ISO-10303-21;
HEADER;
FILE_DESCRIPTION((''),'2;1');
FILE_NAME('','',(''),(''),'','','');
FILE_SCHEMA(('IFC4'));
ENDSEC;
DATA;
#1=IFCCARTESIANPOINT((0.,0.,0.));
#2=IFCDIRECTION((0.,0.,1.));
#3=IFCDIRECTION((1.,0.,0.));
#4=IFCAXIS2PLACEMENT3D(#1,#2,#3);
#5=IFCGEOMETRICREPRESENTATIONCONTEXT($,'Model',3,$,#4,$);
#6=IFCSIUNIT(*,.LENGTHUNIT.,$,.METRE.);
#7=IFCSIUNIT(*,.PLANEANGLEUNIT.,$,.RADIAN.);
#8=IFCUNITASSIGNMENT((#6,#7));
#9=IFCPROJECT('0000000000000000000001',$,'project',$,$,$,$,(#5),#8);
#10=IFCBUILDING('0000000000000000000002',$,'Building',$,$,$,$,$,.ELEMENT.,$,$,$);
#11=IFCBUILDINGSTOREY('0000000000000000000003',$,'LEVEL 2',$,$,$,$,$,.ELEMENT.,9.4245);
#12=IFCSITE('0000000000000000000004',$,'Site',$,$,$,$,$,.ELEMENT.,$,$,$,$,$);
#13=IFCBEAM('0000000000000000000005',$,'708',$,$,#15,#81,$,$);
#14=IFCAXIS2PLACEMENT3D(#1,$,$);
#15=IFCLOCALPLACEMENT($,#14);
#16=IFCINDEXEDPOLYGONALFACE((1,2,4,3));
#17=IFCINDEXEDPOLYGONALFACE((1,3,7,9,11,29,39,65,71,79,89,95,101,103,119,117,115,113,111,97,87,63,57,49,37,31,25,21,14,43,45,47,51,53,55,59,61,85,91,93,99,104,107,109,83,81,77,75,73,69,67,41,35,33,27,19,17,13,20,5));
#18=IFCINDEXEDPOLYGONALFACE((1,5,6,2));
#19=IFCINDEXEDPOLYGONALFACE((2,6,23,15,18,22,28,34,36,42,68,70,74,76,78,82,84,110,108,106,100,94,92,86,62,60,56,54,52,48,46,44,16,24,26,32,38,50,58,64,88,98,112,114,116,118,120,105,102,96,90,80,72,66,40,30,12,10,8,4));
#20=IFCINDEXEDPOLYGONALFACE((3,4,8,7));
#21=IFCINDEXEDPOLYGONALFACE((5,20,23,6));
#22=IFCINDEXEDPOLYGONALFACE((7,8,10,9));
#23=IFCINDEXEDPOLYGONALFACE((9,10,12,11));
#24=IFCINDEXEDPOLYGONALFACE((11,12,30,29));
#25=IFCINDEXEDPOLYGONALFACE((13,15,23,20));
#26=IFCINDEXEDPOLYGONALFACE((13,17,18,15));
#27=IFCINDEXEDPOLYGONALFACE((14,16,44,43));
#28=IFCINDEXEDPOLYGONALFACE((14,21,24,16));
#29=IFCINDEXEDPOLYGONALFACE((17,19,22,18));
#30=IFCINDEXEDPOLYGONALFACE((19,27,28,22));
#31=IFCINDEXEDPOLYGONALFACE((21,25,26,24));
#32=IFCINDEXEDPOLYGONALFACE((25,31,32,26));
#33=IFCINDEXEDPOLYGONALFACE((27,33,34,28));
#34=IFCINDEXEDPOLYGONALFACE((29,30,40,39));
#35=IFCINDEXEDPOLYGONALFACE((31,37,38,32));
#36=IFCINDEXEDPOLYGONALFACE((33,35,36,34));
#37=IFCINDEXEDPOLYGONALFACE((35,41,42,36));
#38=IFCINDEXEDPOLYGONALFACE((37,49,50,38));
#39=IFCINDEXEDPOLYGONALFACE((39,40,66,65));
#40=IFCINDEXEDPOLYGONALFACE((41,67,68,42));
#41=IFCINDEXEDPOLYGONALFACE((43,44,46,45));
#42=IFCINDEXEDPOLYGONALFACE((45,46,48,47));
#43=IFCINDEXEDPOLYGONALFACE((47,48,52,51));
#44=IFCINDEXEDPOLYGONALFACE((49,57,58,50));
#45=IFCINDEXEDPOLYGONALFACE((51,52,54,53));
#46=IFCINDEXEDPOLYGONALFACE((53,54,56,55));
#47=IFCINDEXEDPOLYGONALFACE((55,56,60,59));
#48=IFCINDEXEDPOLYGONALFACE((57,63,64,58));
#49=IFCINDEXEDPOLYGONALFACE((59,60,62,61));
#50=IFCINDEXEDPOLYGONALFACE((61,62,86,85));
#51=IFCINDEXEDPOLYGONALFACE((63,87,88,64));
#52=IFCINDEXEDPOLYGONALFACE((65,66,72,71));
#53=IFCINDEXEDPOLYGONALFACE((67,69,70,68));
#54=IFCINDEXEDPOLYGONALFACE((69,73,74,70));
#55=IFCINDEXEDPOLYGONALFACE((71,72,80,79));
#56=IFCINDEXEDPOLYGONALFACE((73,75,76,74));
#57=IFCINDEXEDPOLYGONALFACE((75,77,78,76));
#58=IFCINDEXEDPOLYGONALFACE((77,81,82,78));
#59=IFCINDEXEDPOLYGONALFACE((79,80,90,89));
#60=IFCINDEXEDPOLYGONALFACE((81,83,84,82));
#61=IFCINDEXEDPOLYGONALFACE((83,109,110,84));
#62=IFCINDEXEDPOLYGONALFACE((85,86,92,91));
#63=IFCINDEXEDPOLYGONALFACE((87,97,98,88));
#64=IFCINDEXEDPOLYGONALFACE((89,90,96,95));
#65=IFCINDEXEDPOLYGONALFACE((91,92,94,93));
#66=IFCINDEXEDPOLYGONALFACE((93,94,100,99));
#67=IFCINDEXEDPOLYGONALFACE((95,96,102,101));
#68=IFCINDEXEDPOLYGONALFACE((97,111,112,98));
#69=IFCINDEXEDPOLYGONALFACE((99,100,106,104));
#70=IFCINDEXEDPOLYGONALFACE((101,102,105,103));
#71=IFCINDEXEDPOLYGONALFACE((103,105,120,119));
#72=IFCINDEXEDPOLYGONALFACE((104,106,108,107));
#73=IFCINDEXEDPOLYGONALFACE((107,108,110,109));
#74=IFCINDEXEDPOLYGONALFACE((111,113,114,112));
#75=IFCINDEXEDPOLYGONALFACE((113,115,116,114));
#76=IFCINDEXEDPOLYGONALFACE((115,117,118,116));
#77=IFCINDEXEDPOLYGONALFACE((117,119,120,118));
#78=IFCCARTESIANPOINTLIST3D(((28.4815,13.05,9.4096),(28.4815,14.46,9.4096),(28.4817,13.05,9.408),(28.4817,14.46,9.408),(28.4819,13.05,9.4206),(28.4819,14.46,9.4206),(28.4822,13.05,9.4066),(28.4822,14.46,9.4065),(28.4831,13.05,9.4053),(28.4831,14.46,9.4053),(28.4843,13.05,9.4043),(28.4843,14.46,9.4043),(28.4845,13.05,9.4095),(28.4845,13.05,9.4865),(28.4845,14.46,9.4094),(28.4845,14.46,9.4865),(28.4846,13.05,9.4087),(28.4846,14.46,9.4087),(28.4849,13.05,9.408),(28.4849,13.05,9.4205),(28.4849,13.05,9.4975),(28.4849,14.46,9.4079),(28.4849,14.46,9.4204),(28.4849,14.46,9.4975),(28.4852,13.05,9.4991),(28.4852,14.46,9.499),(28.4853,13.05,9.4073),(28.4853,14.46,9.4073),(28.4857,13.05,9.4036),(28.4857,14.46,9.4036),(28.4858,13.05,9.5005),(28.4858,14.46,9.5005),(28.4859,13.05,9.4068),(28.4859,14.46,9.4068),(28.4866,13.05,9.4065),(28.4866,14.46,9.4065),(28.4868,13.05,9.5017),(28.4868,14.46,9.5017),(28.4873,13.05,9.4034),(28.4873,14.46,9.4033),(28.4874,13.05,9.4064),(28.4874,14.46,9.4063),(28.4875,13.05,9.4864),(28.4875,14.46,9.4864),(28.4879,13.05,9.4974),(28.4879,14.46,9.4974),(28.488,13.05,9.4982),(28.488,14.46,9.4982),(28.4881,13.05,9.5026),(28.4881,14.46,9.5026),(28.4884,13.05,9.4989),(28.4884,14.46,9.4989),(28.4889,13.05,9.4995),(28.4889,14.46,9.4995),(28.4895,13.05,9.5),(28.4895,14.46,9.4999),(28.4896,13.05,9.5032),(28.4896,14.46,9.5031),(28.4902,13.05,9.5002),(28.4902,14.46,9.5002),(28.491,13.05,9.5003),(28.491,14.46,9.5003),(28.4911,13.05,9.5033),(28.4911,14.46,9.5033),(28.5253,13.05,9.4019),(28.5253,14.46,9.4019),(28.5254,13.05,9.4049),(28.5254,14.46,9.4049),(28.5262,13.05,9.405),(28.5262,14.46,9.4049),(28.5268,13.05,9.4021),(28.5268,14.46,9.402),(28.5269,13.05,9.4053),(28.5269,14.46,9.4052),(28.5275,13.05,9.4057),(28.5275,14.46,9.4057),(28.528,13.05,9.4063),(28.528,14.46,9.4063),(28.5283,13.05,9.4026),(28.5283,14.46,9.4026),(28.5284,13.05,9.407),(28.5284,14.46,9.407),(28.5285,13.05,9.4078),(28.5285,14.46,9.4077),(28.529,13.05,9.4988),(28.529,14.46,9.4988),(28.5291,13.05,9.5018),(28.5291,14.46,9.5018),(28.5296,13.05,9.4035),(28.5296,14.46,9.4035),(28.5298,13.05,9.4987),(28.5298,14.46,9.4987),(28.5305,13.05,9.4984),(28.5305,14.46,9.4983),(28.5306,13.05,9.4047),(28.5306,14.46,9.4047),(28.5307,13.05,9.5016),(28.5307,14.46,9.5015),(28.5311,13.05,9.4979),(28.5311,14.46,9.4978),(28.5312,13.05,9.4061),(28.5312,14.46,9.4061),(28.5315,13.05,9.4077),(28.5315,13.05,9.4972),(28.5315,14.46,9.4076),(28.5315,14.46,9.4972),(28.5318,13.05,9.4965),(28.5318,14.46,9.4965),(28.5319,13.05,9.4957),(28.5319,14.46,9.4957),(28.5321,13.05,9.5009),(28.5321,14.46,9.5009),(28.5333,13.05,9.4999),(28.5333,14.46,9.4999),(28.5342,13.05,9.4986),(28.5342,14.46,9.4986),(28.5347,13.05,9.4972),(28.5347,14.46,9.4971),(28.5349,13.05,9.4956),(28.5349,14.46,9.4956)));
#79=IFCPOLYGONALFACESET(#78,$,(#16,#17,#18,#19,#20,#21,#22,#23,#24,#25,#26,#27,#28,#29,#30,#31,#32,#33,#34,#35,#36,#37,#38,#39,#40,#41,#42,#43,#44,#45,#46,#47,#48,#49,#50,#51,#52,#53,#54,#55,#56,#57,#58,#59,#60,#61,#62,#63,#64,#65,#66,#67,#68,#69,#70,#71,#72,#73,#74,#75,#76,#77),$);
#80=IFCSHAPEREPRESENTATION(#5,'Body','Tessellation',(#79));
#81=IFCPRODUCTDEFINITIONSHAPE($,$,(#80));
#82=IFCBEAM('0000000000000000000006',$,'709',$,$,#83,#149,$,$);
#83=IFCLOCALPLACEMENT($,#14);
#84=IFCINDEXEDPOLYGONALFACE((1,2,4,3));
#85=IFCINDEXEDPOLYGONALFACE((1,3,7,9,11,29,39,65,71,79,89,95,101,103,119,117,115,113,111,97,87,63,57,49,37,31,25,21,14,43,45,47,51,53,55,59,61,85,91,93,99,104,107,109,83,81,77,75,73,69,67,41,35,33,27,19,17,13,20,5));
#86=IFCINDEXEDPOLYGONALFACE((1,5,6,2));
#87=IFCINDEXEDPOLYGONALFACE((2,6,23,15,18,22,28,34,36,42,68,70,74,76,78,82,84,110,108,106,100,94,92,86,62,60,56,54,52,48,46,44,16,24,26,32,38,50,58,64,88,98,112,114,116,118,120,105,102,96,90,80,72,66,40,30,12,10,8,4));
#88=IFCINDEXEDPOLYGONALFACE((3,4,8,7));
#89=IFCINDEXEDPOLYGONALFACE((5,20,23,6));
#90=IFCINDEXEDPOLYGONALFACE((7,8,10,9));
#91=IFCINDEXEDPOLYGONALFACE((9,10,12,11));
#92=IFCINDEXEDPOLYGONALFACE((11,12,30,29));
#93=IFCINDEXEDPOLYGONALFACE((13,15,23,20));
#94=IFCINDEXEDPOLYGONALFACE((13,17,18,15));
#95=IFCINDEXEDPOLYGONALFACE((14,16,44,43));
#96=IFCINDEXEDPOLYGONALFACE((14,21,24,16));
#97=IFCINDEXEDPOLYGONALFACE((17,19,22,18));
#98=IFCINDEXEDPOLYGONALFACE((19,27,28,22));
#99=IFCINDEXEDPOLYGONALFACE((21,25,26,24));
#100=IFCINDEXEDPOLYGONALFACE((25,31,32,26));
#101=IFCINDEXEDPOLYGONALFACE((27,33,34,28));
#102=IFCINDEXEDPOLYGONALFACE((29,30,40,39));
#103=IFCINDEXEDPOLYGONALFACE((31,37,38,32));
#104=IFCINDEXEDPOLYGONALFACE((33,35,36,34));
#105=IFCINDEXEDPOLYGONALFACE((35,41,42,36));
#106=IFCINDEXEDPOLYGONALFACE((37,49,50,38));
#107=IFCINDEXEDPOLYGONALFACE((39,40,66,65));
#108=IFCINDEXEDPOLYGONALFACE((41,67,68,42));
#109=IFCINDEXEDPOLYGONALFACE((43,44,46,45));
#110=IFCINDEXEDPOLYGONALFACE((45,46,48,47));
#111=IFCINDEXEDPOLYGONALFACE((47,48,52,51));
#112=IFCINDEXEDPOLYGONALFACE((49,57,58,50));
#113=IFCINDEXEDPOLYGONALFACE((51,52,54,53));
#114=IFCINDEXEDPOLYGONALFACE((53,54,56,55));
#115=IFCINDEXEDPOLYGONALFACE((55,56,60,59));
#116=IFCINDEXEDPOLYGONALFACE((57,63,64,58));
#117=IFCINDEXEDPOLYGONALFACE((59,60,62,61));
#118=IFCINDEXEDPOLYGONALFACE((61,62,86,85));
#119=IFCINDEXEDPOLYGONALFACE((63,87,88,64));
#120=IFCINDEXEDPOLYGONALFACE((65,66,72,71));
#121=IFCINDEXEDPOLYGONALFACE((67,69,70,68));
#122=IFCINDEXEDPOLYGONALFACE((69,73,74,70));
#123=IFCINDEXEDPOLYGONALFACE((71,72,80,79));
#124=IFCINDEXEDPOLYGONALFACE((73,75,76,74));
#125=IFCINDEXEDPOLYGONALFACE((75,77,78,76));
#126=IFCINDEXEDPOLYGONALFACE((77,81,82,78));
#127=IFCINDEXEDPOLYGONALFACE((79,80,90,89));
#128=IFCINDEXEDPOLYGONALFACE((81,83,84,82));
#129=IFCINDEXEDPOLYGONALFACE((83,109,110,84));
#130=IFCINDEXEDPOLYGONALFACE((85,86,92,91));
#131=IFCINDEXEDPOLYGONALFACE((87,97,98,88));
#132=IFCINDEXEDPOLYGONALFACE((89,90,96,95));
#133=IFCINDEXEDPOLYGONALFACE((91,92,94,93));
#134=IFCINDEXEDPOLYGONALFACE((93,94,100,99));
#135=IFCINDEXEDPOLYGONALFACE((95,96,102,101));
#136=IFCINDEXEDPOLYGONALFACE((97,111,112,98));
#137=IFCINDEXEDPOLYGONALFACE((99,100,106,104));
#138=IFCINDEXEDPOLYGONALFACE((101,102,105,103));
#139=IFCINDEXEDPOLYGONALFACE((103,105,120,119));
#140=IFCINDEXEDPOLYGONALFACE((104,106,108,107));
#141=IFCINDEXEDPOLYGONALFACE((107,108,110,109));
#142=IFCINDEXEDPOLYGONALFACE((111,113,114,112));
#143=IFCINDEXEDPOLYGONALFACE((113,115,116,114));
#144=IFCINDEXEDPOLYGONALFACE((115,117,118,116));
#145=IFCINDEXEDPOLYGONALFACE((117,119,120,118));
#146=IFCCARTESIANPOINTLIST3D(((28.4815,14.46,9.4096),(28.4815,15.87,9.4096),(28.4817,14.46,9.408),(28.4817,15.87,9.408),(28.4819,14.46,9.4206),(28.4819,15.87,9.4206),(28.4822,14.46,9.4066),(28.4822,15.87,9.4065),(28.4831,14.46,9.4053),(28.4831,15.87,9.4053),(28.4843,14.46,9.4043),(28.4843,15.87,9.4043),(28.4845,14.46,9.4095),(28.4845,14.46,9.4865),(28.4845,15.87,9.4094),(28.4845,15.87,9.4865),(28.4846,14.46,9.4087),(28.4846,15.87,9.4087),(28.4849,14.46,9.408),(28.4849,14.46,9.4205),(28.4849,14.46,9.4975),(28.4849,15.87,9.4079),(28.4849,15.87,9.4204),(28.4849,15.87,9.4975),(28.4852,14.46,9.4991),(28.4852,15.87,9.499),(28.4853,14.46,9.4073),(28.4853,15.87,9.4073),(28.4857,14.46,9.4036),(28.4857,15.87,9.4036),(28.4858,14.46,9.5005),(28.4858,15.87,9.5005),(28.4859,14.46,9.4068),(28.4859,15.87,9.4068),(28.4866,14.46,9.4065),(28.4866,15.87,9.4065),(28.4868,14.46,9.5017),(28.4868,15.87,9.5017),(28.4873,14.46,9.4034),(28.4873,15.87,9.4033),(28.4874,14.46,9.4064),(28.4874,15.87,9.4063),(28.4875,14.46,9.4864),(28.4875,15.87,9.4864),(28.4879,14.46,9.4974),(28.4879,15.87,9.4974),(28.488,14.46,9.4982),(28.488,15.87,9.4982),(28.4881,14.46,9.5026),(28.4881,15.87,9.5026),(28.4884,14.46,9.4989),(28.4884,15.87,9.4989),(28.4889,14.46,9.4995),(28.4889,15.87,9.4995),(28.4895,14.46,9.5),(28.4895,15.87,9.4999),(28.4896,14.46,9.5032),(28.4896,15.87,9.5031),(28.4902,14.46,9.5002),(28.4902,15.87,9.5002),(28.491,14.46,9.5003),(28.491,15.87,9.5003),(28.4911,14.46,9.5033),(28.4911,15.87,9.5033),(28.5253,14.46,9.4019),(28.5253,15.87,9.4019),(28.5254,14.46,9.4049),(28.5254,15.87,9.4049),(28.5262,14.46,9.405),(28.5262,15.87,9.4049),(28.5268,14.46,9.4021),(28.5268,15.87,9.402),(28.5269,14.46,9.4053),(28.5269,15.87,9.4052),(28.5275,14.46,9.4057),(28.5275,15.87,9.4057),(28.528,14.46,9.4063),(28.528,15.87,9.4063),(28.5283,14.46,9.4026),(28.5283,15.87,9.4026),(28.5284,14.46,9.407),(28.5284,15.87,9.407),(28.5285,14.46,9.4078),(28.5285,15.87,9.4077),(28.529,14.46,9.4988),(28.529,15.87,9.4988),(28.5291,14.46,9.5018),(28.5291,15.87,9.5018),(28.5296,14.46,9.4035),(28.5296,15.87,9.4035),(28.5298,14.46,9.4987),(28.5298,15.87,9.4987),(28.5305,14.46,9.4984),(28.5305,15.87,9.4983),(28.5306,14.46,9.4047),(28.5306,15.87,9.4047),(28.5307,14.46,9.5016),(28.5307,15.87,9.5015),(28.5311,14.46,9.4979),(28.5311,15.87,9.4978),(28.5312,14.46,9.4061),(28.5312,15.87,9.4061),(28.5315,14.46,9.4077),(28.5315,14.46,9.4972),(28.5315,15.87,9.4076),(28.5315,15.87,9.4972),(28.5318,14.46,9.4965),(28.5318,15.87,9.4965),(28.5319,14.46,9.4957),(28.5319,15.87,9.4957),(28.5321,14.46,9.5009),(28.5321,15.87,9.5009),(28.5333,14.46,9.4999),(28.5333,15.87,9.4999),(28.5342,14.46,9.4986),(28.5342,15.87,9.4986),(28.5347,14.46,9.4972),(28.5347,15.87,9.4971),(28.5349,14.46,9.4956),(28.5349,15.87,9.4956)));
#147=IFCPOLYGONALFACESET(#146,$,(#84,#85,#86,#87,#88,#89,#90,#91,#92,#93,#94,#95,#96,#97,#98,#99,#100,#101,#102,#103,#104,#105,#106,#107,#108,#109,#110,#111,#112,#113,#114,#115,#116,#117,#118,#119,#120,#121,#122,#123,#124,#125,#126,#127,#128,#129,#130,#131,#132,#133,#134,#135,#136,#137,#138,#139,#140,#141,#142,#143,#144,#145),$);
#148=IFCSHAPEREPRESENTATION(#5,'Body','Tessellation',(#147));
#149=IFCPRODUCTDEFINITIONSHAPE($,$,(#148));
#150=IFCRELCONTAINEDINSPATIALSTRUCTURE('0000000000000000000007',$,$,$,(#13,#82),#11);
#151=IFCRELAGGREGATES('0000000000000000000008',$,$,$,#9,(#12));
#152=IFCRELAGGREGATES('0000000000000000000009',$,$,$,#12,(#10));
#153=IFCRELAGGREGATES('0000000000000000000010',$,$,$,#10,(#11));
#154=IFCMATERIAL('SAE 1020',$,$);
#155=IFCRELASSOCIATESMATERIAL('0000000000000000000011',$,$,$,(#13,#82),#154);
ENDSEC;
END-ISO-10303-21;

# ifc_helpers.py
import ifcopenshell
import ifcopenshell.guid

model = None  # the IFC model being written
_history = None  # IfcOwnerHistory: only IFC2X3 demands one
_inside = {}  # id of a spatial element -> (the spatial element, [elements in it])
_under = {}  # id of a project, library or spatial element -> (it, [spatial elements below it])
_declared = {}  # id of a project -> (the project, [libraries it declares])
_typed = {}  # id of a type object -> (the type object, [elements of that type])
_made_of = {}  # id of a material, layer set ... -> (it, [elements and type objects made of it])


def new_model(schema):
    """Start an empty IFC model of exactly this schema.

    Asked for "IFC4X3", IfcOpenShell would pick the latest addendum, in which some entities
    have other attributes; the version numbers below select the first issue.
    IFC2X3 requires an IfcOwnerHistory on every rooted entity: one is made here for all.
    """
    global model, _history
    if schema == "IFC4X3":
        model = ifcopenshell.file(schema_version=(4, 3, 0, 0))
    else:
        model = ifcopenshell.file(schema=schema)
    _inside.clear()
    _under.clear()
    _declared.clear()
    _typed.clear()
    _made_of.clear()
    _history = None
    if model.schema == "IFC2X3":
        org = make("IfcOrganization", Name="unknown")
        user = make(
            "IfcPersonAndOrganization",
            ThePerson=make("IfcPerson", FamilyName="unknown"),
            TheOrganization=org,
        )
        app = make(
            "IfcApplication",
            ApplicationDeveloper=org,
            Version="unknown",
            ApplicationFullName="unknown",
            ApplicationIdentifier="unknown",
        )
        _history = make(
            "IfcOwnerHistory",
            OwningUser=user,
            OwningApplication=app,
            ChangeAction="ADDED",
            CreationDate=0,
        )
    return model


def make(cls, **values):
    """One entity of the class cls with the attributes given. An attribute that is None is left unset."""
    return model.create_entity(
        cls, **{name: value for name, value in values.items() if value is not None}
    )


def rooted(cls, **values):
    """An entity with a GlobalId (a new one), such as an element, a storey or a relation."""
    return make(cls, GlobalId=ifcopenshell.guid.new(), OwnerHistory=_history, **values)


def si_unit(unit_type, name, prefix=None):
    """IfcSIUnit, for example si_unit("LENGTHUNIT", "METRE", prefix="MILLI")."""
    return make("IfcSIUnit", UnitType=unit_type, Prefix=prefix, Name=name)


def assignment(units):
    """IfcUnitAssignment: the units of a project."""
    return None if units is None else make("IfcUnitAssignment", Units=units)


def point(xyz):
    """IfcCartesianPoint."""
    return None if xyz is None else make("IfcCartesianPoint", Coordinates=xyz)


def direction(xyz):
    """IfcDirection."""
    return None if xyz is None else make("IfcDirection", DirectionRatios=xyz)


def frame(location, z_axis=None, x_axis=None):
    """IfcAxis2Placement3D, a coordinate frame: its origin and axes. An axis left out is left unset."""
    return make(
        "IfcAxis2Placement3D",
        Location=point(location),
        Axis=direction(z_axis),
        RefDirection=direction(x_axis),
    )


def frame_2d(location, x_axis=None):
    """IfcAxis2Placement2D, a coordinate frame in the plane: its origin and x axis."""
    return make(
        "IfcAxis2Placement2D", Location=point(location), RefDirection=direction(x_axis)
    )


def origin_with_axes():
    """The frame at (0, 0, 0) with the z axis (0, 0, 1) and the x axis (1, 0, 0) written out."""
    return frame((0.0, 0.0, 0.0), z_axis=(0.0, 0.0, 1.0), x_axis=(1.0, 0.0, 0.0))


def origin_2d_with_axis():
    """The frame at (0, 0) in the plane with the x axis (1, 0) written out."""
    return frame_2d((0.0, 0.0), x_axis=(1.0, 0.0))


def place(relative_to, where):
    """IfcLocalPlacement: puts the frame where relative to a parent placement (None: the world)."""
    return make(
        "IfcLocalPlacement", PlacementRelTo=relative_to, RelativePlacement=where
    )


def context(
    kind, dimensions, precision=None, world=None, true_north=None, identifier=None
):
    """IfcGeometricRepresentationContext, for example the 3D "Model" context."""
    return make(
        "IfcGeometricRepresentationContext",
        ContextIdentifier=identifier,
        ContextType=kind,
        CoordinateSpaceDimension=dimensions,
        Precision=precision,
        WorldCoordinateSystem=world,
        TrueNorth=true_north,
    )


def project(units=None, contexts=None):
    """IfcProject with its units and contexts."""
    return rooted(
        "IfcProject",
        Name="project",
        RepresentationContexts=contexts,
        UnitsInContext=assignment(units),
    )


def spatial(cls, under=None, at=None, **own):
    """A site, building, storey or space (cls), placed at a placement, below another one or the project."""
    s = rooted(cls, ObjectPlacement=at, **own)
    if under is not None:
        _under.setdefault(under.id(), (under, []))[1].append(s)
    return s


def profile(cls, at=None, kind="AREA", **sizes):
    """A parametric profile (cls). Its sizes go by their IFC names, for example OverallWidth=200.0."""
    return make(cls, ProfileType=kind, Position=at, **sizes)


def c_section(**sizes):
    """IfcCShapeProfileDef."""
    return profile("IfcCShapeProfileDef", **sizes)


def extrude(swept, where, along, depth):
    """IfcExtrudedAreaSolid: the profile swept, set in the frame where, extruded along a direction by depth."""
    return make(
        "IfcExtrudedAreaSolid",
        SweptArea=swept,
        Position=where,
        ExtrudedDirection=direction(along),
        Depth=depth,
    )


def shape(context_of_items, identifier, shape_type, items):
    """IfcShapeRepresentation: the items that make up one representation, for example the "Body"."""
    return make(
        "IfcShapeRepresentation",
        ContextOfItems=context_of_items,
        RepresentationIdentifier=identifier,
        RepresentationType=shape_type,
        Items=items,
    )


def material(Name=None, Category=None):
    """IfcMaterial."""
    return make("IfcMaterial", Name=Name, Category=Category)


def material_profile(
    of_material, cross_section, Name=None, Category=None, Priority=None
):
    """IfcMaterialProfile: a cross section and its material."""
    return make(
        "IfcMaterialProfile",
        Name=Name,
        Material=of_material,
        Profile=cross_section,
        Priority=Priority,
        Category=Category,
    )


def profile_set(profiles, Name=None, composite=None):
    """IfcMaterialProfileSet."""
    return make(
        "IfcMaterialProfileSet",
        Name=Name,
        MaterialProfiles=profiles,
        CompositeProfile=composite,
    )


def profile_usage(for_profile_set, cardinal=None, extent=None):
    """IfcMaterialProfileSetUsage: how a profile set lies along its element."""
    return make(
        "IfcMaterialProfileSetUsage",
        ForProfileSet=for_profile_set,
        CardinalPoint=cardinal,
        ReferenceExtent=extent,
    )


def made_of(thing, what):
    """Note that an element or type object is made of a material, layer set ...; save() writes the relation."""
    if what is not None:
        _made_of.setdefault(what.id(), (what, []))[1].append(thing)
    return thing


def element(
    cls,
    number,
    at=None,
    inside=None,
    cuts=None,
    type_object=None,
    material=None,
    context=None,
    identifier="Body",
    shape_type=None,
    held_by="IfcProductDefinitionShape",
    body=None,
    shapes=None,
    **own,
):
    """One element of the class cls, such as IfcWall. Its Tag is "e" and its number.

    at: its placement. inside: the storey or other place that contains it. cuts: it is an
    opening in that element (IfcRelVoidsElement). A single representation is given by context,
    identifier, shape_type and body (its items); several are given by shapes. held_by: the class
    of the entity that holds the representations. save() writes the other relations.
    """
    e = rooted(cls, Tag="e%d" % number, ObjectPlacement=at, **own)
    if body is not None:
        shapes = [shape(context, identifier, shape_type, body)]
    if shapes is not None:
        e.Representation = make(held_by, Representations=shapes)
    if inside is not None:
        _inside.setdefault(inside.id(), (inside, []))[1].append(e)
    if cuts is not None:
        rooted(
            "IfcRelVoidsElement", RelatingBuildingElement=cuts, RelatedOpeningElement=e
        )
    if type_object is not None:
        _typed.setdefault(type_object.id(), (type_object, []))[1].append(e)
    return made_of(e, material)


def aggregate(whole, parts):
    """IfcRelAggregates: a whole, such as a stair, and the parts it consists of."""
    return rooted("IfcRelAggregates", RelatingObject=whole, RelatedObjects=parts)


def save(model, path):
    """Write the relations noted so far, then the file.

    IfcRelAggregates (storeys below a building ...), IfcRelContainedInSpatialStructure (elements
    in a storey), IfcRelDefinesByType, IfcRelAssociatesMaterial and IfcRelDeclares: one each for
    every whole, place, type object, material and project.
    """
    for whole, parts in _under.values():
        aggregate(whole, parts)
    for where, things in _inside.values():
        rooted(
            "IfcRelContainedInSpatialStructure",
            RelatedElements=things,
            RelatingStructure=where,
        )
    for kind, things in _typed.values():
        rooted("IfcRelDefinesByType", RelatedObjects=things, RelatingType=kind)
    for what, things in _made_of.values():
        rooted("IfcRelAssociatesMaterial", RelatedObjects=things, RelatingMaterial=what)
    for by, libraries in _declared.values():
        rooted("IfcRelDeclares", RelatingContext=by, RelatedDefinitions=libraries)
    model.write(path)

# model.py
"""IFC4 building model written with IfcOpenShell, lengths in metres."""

from ifc_helpers import new_model, si_unit, frame, origin_with_axes, origin_2d_with_axis, place, context, project, spatial, c_section, extrude, material, material_profile, profile_set, profile_usage, element, save


model = new_model("IFC4")

# Units and contexts
model_context = context("Model", 3, world=origin_with_axes())
ifc_project = project(units=[si_unit("LENGTHUNIT", "METRE"), si_unit("PLANEANGLEUNIT", "RADIAN")], contexts=[model_context])

# Site, building, storey
site = spatial("IfcSite", under=ifc_project, Name="Site", CompositionType="ELEMENT")
building = spatial("IfcBuilding", under=site, Name="Building", CompositionType="ELEMENT")
storey = spatial("IfcBuildingStorey", under=building, Name="LEVEL 2", CompositionType="ELEMENT", Elevation=9.4245)

# Beams
ifc_material = material(Name="SAE 1020")
ifc_material_profile_1 = material_profile(ifc_material, c_section(Depth=0.1, Width=0.05, WallThickness=0.003, Girth=0.017, InternalFilletRadius=0.003, at=origin_2d_with_axis()))
ifc_profile_set_1 = profile_set([ifc_material_profile_1])
ifc_profile_usage_1 = profile_usage(ifc_profile_set_1, cardinal=10)
beam_1_placement = place(None, frame((28.5082, 13.05, 9.4526), z_axis=(0.0, 1.0, -0.00003), x_axis=(-0.999256, 0.000001, 0.038562)))
element("IfcBeam", 1, at=beam_1_placement, inside=storey, material=ifc_profile_usage_1, Name="708", context=model_context, shape_type="SweptSolid", body=[
    extrude(c_section(Depth=0.1, Width=0.05, WallThickness=0.003, Girth=0.017, InternalFilletRadius=0.003, at=origin_2d_with_axis()), origin_with_axes(), (0.0, 0.0, 1.0), 1.41),
])
ifc_material_profile_2 = material_profile(ifc_material, c_section(Depth=0.1, Width=0.05, WallThickness=0.003, Girth=0.017, InternalFilletRadius=0.003, at=origin_2d_with_axis()))
ifc_profile_set_2 = profile_set([ifc_material_profile_2])
ifc_profile_usage_2 = profile_usage(ifc_profile_set_2, cardinal=10)
beam_2_placement = place(None, frame((28.5082, 14.46, 9.4526), z_axis=(0.0, 1.0, -0.00003), x_axis=(-0.999256, 0.000001, 0.038562)))
element("IfcBeam", 2, at=beam_2_placement, inside=storey, material=ifc_profile_usage_2, Name="709", context=model_context, shape_type="SweptSolid", body=[
    extrude(c_section(Depth=0.1, Width=0.05, WallThickness=0.003, Girth=0.017, InternalFilletRadius=0.003, at=origin_2d_with_axis()), origin_with_axes(), (0.0, 0.0, 1.0), 1.41),
])

save(model, "model.ifc")
